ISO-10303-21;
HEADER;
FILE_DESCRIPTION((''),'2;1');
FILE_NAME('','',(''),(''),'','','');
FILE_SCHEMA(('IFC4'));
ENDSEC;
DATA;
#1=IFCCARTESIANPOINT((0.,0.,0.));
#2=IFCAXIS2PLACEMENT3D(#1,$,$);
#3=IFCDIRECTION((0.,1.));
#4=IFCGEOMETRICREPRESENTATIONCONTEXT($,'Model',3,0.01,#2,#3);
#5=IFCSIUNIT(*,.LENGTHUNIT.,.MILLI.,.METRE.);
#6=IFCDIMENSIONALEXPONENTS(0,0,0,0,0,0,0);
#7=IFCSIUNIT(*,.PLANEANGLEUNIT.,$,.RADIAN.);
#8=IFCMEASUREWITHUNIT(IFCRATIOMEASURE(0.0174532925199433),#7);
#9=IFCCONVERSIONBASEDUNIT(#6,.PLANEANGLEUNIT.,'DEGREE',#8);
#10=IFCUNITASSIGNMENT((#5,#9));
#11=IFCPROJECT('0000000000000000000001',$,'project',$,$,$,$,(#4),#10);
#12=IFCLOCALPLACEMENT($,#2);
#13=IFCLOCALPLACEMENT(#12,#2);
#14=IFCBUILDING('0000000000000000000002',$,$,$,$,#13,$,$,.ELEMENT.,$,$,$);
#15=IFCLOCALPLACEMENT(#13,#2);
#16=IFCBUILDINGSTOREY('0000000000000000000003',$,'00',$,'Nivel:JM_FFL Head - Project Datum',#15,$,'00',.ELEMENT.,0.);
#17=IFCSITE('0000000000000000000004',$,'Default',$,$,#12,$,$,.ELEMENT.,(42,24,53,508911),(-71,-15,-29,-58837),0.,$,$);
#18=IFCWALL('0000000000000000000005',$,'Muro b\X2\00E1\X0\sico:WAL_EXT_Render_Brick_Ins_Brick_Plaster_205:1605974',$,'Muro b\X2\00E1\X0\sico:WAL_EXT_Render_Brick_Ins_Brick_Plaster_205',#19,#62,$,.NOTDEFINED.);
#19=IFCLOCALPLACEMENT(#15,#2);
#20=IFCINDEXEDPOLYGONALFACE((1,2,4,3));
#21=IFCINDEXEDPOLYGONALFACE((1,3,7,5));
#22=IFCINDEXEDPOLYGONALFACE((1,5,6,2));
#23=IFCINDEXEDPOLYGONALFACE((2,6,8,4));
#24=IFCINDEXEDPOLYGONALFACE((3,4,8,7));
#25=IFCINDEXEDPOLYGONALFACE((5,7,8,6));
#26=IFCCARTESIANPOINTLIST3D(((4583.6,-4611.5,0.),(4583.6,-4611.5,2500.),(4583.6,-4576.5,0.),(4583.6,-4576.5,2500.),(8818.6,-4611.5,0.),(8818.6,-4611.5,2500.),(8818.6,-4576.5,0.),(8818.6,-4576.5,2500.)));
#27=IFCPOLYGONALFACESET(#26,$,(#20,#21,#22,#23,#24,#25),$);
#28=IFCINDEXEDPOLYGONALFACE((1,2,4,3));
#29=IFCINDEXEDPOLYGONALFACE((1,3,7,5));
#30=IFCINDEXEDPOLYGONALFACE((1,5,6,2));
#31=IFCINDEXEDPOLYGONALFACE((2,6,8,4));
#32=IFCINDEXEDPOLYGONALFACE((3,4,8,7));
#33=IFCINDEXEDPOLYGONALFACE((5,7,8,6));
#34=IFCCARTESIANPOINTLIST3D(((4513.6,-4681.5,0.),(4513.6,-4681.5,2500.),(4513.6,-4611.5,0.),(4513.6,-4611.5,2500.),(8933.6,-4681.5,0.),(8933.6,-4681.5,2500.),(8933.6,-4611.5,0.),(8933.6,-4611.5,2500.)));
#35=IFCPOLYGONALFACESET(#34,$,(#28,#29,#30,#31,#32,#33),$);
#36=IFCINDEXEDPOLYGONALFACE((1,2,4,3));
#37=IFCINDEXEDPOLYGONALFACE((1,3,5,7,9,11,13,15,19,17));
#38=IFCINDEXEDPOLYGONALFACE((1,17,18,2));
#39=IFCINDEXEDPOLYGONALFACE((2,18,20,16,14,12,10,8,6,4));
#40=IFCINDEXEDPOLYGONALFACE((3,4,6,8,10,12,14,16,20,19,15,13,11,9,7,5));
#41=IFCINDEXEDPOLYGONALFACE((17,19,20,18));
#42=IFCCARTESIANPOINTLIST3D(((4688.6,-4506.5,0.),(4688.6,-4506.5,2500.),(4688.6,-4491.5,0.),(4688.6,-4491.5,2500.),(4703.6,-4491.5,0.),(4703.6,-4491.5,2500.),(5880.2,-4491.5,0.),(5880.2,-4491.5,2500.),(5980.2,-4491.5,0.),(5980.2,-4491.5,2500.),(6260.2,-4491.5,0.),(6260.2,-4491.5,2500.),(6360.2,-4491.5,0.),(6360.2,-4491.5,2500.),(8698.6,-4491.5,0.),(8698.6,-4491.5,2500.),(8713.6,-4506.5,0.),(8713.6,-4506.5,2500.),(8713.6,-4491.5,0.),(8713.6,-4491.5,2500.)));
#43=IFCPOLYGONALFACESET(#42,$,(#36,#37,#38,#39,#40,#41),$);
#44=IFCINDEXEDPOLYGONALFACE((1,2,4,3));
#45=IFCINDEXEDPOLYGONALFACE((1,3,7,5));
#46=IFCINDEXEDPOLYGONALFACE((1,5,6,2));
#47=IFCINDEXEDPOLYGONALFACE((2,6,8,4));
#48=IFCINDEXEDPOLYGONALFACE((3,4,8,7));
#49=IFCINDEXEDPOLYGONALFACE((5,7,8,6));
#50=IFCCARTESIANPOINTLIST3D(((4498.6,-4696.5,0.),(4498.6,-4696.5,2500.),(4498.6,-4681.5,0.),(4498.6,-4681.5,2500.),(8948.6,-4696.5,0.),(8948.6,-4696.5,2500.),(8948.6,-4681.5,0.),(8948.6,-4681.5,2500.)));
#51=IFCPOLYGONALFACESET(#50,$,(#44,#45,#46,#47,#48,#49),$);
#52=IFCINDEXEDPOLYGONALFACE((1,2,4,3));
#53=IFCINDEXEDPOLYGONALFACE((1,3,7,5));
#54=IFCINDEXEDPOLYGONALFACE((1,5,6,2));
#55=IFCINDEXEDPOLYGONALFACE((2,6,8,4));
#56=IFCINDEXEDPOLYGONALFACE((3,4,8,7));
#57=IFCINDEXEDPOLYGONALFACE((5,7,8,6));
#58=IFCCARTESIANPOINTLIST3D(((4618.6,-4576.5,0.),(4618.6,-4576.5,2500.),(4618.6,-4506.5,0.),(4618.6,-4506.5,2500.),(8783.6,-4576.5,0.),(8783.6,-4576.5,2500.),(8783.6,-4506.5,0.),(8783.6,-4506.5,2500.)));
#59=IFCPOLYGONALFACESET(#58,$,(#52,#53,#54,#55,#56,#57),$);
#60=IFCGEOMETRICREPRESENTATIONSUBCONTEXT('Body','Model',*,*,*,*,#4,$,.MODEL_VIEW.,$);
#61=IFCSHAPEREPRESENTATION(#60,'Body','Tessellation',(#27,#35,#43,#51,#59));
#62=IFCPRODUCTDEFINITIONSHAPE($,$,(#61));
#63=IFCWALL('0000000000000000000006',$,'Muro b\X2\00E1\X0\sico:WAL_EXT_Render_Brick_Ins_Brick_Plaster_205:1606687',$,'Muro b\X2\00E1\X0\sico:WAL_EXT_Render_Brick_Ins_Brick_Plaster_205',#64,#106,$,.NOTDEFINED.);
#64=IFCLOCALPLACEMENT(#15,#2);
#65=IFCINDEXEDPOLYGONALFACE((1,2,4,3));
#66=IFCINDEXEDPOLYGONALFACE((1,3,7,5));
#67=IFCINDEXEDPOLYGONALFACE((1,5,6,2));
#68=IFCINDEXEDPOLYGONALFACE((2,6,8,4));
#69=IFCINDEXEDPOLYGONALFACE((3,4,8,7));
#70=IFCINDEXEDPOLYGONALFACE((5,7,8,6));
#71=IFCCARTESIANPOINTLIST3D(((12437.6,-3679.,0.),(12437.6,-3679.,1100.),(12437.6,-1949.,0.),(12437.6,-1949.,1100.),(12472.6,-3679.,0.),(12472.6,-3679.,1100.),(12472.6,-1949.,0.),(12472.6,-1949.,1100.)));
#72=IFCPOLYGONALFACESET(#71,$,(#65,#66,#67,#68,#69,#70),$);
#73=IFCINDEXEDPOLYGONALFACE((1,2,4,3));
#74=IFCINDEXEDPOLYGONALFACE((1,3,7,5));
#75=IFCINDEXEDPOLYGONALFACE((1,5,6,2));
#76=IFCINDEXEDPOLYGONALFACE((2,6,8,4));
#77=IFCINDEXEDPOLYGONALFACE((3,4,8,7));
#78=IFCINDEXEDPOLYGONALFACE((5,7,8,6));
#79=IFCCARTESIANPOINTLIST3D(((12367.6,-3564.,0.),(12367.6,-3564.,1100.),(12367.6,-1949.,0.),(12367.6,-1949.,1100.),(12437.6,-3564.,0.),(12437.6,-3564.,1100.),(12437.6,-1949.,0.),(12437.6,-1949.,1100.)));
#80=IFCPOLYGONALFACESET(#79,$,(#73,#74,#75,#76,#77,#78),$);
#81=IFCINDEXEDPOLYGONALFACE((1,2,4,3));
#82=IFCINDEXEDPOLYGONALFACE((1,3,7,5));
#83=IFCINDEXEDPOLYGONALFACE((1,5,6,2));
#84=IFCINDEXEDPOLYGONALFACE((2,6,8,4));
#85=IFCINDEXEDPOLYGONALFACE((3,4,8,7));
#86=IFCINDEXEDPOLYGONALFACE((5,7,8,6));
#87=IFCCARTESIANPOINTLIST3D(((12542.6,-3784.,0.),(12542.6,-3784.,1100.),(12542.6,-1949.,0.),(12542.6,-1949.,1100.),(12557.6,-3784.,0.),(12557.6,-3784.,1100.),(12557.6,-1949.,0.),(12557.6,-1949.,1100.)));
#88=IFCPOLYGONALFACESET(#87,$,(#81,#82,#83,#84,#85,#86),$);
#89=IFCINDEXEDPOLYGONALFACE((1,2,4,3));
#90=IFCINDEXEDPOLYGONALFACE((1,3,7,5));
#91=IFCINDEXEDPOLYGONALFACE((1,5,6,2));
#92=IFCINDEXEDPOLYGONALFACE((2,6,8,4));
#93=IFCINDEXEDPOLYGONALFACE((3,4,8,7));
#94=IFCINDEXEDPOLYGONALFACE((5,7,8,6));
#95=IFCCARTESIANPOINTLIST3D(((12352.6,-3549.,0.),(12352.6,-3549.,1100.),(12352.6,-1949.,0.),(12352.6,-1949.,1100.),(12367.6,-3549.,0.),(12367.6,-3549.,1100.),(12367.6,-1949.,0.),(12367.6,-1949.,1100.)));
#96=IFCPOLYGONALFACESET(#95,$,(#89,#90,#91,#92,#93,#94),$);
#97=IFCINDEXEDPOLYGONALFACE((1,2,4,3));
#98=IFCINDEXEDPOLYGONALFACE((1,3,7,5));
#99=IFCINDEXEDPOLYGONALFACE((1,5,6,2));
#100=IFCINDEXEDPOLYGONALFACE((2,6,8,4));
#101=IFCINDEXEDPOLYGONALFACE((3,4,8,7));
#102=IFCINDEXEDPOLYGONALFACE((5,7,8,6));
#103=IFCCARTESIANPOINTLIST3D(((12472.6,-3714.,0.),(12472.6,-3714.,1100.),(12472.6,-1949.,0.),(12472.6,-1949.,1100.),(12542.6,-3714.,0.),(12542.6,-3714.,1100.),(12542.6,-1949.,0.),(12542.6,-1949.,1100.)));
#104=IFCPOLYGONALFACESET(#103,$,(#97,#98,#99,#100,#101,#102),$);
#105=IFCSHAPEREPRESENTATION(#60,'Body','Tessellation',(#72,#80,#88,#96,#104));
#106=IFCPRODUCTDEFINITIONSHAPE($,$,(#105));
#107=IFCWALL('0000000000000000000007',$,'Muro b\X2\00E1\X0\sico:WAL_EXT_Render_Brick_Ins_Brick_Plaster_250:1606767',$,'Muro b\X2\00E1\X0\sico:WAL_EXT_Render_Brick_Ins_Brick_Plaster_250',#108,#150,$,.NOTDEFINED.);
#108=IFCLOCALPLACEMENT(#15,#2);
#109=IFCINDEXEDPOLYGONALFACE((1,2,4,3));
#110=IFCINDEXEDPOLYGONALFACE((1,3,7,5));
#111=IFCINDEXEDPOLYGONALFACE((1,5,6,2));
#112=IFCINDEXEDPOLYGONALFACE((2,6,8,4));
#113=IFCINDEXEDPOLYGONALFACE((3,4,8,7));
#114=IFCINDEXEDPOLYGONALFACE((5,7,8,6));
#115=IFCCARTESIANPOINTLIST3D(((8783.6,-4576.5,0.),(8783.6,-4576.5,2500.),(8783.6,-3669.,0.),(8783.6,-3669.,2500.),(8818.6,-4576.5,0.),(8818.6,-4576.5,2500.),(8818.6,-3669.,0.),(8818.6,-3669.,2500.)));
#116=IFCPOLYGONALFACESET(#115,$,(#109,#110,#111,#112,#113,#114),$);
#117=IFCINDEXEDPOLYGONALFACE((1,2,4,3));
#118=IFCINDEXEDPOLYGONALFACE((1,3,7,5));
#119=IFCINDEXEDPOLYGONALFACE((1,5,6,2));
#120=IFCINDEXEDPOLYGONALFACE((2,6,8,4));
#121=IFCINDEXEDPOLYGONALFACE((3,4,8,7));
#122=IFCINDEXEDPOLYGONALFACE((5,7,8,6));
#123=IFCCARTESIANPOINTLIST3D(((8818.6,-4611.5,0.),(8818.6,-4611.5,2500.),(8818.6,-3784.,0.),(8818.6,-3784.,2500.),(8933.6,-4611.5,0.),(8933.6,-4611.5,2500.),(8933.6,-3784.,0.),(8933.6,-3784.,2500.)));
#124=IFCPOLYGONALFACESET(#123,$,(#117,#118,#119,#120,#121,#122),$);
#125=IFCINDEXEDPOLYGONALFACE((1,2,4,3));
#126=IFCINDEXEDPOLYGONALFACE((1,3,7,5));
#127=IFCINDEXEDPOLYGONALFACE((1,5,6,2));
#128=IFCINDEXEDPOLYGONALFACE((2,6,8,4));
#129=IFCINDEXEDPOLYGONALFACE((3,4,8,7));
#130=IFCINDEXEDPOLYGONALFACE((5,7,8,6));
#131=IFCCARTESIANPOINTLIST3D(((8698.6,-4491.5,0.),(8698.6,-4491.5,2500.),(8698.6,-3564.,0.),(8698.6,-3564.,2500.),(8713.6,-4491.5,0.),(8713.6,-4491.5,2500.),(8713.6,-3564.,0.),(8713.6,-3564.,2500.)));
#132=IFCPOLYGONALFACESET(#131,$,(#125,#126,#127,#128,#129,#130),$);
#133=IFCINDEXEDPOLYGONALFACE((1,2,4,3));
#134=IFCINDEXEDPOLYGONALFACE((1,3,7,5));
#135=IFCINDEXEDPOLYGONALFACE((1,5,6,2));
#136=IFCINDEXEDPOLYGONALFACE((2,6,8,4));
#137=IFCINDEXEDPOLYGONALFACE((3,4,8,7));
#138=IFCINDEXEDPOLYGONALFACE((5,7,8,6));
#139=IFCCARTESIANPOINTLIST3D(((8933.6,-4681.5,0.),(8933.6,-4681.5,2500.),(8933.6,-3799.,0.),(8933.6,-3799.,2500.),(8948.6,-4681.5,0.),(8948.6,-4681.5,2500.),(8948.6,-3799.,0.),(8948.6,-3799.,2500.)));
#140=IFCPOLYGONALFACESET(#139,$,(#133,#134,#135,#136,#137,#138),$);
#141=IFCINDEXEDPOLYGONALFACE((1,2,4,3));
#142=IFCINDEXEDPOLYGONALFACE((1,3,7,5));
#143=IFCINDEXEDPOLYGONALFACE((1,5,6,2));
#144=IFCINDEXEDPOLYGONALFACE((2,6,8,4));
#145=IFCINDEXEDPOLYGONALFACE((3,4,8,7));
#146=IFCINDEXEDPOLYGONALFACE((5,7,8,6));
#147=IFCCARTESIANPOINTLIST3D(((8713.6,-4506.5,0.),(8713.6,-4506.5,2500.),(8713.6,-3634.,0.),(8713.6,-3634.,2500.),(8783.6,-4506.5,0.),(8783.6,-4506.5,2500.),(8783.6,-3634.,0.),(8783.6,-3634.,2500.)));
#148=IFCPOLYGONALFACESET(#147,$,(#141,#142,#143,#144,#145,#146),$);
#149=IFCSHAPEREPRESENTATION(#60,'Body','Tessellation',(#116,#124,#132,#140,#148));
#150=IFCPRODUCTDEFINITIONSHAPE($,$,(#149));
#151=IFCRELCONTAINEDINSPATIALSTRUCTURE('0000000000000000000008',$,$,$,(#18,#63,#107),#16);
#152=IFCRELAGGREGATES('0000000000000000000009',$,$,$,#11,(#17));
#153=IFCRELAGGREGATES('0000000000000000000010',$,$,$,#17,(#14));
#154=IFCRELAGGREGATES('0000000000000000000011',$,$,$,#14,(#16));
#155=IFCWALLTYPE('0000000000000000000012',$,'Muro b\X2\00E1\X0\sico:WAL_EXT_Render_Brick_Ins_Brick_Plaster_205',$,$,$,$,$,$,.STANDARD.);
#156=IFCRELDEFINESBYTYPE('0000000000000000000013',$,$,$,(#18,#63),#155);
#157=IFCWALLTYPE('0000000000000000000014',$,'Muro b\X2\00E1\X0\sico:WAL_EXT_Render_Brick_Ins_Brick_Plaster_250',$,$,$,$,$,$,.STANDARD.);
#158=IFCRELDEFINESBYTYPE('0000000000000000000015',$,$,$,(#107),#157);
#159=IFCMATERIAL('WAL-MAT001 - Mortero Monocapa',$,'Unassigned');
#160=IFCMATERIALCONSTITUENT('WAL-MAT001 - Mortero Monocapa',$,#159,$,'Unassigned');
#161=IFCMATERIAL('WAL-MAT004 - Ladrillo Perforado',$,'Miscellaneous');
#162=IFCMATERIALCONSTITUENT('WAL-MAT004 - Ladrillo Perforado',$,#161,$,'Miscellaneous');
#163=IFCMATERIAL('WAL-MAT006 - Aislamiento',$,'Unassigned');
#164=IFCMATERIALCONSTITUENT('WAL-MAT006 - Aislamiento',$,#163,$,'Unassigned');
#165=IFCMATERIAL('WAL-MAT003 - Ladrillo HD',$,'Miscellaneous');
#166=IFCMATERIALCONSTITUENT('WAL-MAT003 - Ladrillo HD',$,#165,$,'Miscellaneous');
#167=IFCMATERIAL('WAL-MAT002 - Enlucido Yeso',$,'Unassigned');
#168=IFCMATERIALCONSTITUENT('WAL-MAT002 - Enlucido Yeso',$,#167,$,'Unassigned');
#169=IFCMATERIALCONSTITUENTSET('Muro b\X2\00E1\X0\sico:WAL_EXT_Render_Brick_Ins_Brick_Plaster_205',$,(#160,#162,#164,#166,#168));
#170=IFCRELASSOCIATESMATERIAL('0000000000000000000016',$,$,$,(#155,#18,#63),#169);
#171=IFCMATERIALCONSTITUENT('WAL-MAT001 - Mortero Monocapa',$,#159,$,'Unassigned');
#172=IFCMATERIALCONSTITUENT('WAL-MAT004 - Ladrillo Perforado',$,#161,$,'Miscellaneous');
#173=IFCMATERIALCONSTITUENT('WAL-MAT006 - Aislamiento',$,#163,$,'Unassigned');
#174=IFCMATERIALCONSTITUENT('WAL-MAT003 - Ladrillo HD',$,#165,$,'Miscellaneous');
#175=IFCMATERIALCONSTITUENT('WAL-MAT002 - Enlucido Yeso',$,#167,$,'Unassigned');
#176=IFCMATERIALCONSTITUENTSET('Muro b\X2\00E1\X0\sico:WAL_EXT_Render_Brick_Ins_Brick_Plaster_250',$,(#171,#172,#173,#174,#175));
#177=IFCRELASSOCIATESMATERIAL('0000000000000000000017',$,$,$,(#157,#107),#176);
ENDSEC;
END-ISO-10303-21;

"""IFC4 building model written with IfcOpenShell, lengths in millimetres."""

from ifc_helpers import new_model, entity, si_unit, converted_unit, direction, frame, origin, place, context, subcontext, project, spatial, indexed_curve, outline, extrude, material, constituent, constituent_set, type_object, element, save


model = new_model("IFC4")

# Units and contexts
model_context = context("Model", 3, precision=0.01, world=origin(), true_north=direction((0.0, 1.0)))
body_context = subcontext(model_context, "Body", "Model", "MODEL_VIEW")
ifc_project = project(units=[si_unit("LENGTHUNIT", "METRE", prefix="MILLI"), converted_unit("PLANEANGLEUNIT", "DEGREE", entity("IfcRatioMeasure", 0.0174532925199433), si_unit("PLANEANGLEUNIT", "RADIAN"), dimensions=[0, 0, 0, 0, 0, 0, 0])], contexts=[model_context])

# Site, building, storey
site_placement = place(None, origin())
site = spatial("IfcSite", under=ifc_project, at=site_placement, Name="Default", CompositionType="ELEMENT", RefLatitude=(42, 24, 53, 508911), RefLongitude=(-71, -15, -29, -58837), RefElevation=0.0)
building_placement = place(site_placement, origin())
building = spatial("IfcBuilding", under=site, at=building_placement, CompositionType="ELEMENT")
storey_placement = place(building_placement, origin())
storey = spatial("IfcBuildingStorey", under=building, at=storey_placement, Name="00", ObjectType="Nivel:JM_FFL Head - Project Datum", LongName="00", CompositionType="ELEMENT", Elevation=0.0)

# Walls
ifc_material_1 = material(Name="WAL-MAT001 - Mortero Monocapa", Category="Unassigned")
ifc_constituent_1 = constituent(ifc_material_1, Name="WAL-MAT001 - Mortero Monocapa", Category="Unassigned")
ifc_material_2 = material(Name="WAL-MAT004 - Ladrillo Perforado", Category="Miscellaneous")
ifc_constituent_2 = constituent(ifc_material_2, Name="WAL-MAT004 - Ladrillo Perforado", Category="Miscellaneous")
ifc_material_3 = material(Name="WAL-MAT006 - Aislamiento", Category="Unassigned")
ifc_constituent_3 = constituent(ifc_material_3, Name="WAL-MAT006 - Aislamiento", Category="Unassigned")
ifc_material_4 = material(Name="WAL-MAT003 - Ladrillo HD", Category="Miscellaneous")
ifc_constituent_4 = constituent(ifc_material_4, Name="WAL-MAT003 - Ladrillo HD", Category="Miscellaneous")
ifc_material_5 = material(Name="WAL-MAT002 - Enlucido Yeso", Category="Unassigned")
ifc_constituent_5 = constituent(ifc_material_5, Name="WAL-MAT002 - Enlucido Yeso", Category="Unassigned")
ifc_constituent_set_1 = constituent_set(constituents=[ifc_constituent_1, ifc_constituent_2, ifc_constituent_3, ifc_constituent_4, ifc_constituent_5], Name="Muro básico:WAL_EXT_Render_Brick_Ins_Brick_Plaster_205")
wall_type_1 = type_object("IfcWallType", Name="Muro básico:WAL_EXT_Render_Brick_Ins_Brick_Plaster_205", PredefinedType="STANDARD", material=ifc_constituent_set_1)
wall_1_placement = place(storey_placement, frame((8948.6, -4594.0, 0.0), z_axis=(0.0, 0.0, 1.0), x_axis=(-1.0, 0.0, 0.0)))
element("IfcWall", 1, at=wall_1_placement, inside=storey, type_object=wall_type_1, material=ifc_constituent_set_1, Name="Muro básico:WAL_EXT_Render_Brick_Ins_Brick_Plaster_205:1605974", ObjectType="Muro básico:WAL_EXT_Render_Brick_Ins_Brick_Plaster_205", PredefinedType="NOTDEFINED", context=body_context, shape_type="SweptSolid", body=[
    extrude(outline(indexed_curve([(-2117.5, -17.5), (2117.5, -17.5), (2117.5, 17.5), (-2117.5, 17.5), (-2117.5, -17.5)], self_intersect=False)), frame((2247.5, 0.0, 0.0)), (0.0, 0.0, 1.0), 2500.0),
    extrude(outline(indexed_curve([(-2210.0, -35.0), (2210.0, -35.0), (2210.0, 35.0), (-2210.0, 35.0), (-2210.0, -35.0)], self_intersect=False)), frame((2225.0, 52.5, 0.0)), (0.0, 0.0, 1.0), 2500.0),
    extrude(outline(indexed_curve([(-2229.9, -3.0), (108.6, -3.0), (208.6, -3.0), (488.6, -3.0), (588.6, -3.0), (1765.1, -3.0), (1780.1, -3.0), (1780.1, 12.0), (-2244.9, 12.0), (-2244.9, -3.0), (-2229.9, -3.0)], self_intersect=False)), frame((2479.9, -99.5, 0.0)), (0.0, 0.0, 1.0), 2500.0),
    extrude(outline(indexed_curve([(-7.5, -2225.0), (7.5, -2225.0), (7.5, 2225.0), (-7.5, 2225.0), (-7.5, -2225.0)], self_intersect=False)), frame((2225.0, 95.0, 0.0), z_axis=(0.0, 0.0, 1.0), x_axis=(0.0, -1.0, 0.0)), (0.0, 0.0, 1.0), 2500.0),
    extrude(outline(indexed_curve([(-2082.5, -35.0), (2082.5, -35.0), (2082.5, 35.0), (-2082.5, 35.0), (-2082.5, -35.0)], self_intersect=False)), frame((2247.5, -52.5, 0.0)), (0.0, 0.0, 1.0), 2500.0),
])
wall_2_placement = place(storey_placement, frame((12455.1, -1949.0, 0.0), z_axis=(0.0, 0.0, 1.0), x_axis=(0.0, -1.0, 0.0)))
element("IfcWall", 2, at=wall_2_placement, inside=storey, type_object=wall_type_1, material=ifc_constituent_set_1, Name="Muro básico:WAL_EXT_Render_Brick_Ins_Brick_Plaster_205:1606687", ObjectType="Muro básico:WAL_EXT_Render_Brick_Ins_Brick_Plaster_205", PredefinedType="NOTDEFINED", context=body_context, shape_type="SweptSolid", body=[
    extrude(outline(indexed_curve([(-865.0, -17.5), (865.0, -17.5), (865.0, 17.5), (-865.0, 17.5), (-865.0, -17.5)], self_intersect=False)), frame((865.0, 0.0, 0.0)), (0.0, 0.0, 1.0), 1100.0),
    extrude(outline(indexed_curve([(-807.5, -35.0), (807.5, -35.0), (807.5, 35.0), (-807.5, 35.0), (-807.5, -35.0)], self_intersect=False)), frame((807.5, -52.5, 0.0)), (0.0, 0.0, 1.0), 1100.0),
    extrude(outline(indexed_curve([(-7.5, -917.5), (7.5, -917.5), (7.5, 917.5), (-7.5, 917.5), (-7.5, -917.5)], self_intersect=False)), frame((917.5, 95.0, 0.0), z_axis=(0.0, 0.0, 1.0), x_axis=(0.0, -1.0, 0.0)), (0.0, 0.0, 1.0), 1100.0),
    extrude(outline(indexed_curve([(-7.5, -800.0), (7.5, -800.0), (7.5, 800.0), (-7.5, 800.0), (-7.5, -800.0)], self_intersect=False)), frame((800.0, -95.0, 0.0), z_axis=(0.0, 0.0, 1.0), x_axis=(0.0, 1.0, 0.0)), (0.0, 0.0, 1.0), 1100.0),
    extrude(outline(indexed_curve([(-882.5, -35.0), (882.5, -35.0), (882.5, 35.0), (-882.5, 35.0), (-882.5, -35.0)], self_intersect=False)), frame((882.5, 52.5, 0.0)), (0.0, 0.0, 1.0), 1100.0),
])
ifc_constituent_6 = constituent(ifc_material_1, Name="WAL-MAT001 - Mortero Monocapa", Category="Unassigned")
ifc_constituent_7 = constituent(ifc_material_2, Name="WAL-MAT004 - Ladrillo Perforado", Category="Miscellaneous")
ifc_constituent_8 = constituent(ifc_material_3, Name="WAL-MAT006 - Aislamiento", Category="Unassigned")
ifc_constituent_9 = constituent(ifc_material_4, Name="WAL-MAT003 - Ladrillo HD", Category="Miscellaneous")
ifc_constituent_10 = constituent(ifc_material_5, Name="WAL-MAT002 - Enlucido Yeso", Category="Unassigned")
ifc_constituent_set_2 = constituent_set(constituents=[ifc_constituent_6, ifc_constituent_7, ifc_constituent_8, ifc_constituent_9, ifc_constituent_10], Name="Muro básico:WAL_EXT_Render_Brick_Ins_Brick_Plaster_250")
wall_type_2 = type_object("IfcWallType", Name="Muro básico:WAL_EXT_Render_Brick_Ins_Brick_Plaster_250", PredefinedType="STANDARD", material=ifc_constituent_set_2)
wall_3_placement = place(storey_placement, frame((8823.6, -4491.5, 0.0), z_axis=(0.0, 0.0, 1.0), x_axis=(0.0, 1.0, 0.0)))
element("IfcWall", 3, at=wall_3_placement, inside=storey, type_object=wall_type_2, material=ifc_constituent_set_2, Name="Muro básico:WAL_EXT_Render_Brick_Ins_Brick_Plaster_250:1606767", ObjectType="Muro básico:WAL_EXT_Render_Brick_Ins_Brick_Plaster_250", PredefinedType="NOTDEFINED", context=body_context, shape_type="SweptSolid", body=[
    extrude(outline(indexed_curve([(-453.7, -17.5), (453.7, -17.5), (453.7, 17.5), (-453.7, 17.5), (-453.7, -17.5)], self_intersect=False)), frame((368.7, 22.5, 0.0)), (0.0, 0.0, 1.0), 2500.0),
    extrude(outline(indexed_curve([(-413.7, -57.5), (413.7, -57.5), (413.7, 57.5), (-413.7, 57.5), (-413.7, -57.5)], self_intersect=False)), frame((293.7, -52.5, 0.0)), (0.0, 0.0, 1.0), 2500.0),
    extrude(outline(indexed_curve([(-7.5, -463.7), (7.5, -463.7), (7.5, 463.7), (-7.5, 463.7), (-7.5, -463.7)], self_intersect=False)), frame((463.7, 117.5, 0.0), z_axis=(0.0, 0.0, 1.0), x_axis=(0.0, -1.0, 0.0)), (0.0, 0.0, 1.0), 2500.0),
    extrude(outline(indexed_curve([(-7.5, -441.2), (7.5, -441.2), (7.5, 441.2), (-7.5, 441.2), (-7.5, -441.2)], self_intersect=False)), frame((251.2, -117.5, 0.0), z_axis=(0.0, 0.0, 1.0), x_axis=(0.0, 1.0, 0.0)), (0.0, 0.0, 1.0), 2500.0),
    extrude(outline(indexed_curve([(-436.2, -35.0), (436.2, -35.0), (436.2, 35.0), (-436.2, 35.0), (-436.2, -35.0)], self_intersect=False)), frame((421.2, 75.0, 0.0)), (0.0, 0.0, 1.0), 2500.0),
])

save(model, "model.ifc")
